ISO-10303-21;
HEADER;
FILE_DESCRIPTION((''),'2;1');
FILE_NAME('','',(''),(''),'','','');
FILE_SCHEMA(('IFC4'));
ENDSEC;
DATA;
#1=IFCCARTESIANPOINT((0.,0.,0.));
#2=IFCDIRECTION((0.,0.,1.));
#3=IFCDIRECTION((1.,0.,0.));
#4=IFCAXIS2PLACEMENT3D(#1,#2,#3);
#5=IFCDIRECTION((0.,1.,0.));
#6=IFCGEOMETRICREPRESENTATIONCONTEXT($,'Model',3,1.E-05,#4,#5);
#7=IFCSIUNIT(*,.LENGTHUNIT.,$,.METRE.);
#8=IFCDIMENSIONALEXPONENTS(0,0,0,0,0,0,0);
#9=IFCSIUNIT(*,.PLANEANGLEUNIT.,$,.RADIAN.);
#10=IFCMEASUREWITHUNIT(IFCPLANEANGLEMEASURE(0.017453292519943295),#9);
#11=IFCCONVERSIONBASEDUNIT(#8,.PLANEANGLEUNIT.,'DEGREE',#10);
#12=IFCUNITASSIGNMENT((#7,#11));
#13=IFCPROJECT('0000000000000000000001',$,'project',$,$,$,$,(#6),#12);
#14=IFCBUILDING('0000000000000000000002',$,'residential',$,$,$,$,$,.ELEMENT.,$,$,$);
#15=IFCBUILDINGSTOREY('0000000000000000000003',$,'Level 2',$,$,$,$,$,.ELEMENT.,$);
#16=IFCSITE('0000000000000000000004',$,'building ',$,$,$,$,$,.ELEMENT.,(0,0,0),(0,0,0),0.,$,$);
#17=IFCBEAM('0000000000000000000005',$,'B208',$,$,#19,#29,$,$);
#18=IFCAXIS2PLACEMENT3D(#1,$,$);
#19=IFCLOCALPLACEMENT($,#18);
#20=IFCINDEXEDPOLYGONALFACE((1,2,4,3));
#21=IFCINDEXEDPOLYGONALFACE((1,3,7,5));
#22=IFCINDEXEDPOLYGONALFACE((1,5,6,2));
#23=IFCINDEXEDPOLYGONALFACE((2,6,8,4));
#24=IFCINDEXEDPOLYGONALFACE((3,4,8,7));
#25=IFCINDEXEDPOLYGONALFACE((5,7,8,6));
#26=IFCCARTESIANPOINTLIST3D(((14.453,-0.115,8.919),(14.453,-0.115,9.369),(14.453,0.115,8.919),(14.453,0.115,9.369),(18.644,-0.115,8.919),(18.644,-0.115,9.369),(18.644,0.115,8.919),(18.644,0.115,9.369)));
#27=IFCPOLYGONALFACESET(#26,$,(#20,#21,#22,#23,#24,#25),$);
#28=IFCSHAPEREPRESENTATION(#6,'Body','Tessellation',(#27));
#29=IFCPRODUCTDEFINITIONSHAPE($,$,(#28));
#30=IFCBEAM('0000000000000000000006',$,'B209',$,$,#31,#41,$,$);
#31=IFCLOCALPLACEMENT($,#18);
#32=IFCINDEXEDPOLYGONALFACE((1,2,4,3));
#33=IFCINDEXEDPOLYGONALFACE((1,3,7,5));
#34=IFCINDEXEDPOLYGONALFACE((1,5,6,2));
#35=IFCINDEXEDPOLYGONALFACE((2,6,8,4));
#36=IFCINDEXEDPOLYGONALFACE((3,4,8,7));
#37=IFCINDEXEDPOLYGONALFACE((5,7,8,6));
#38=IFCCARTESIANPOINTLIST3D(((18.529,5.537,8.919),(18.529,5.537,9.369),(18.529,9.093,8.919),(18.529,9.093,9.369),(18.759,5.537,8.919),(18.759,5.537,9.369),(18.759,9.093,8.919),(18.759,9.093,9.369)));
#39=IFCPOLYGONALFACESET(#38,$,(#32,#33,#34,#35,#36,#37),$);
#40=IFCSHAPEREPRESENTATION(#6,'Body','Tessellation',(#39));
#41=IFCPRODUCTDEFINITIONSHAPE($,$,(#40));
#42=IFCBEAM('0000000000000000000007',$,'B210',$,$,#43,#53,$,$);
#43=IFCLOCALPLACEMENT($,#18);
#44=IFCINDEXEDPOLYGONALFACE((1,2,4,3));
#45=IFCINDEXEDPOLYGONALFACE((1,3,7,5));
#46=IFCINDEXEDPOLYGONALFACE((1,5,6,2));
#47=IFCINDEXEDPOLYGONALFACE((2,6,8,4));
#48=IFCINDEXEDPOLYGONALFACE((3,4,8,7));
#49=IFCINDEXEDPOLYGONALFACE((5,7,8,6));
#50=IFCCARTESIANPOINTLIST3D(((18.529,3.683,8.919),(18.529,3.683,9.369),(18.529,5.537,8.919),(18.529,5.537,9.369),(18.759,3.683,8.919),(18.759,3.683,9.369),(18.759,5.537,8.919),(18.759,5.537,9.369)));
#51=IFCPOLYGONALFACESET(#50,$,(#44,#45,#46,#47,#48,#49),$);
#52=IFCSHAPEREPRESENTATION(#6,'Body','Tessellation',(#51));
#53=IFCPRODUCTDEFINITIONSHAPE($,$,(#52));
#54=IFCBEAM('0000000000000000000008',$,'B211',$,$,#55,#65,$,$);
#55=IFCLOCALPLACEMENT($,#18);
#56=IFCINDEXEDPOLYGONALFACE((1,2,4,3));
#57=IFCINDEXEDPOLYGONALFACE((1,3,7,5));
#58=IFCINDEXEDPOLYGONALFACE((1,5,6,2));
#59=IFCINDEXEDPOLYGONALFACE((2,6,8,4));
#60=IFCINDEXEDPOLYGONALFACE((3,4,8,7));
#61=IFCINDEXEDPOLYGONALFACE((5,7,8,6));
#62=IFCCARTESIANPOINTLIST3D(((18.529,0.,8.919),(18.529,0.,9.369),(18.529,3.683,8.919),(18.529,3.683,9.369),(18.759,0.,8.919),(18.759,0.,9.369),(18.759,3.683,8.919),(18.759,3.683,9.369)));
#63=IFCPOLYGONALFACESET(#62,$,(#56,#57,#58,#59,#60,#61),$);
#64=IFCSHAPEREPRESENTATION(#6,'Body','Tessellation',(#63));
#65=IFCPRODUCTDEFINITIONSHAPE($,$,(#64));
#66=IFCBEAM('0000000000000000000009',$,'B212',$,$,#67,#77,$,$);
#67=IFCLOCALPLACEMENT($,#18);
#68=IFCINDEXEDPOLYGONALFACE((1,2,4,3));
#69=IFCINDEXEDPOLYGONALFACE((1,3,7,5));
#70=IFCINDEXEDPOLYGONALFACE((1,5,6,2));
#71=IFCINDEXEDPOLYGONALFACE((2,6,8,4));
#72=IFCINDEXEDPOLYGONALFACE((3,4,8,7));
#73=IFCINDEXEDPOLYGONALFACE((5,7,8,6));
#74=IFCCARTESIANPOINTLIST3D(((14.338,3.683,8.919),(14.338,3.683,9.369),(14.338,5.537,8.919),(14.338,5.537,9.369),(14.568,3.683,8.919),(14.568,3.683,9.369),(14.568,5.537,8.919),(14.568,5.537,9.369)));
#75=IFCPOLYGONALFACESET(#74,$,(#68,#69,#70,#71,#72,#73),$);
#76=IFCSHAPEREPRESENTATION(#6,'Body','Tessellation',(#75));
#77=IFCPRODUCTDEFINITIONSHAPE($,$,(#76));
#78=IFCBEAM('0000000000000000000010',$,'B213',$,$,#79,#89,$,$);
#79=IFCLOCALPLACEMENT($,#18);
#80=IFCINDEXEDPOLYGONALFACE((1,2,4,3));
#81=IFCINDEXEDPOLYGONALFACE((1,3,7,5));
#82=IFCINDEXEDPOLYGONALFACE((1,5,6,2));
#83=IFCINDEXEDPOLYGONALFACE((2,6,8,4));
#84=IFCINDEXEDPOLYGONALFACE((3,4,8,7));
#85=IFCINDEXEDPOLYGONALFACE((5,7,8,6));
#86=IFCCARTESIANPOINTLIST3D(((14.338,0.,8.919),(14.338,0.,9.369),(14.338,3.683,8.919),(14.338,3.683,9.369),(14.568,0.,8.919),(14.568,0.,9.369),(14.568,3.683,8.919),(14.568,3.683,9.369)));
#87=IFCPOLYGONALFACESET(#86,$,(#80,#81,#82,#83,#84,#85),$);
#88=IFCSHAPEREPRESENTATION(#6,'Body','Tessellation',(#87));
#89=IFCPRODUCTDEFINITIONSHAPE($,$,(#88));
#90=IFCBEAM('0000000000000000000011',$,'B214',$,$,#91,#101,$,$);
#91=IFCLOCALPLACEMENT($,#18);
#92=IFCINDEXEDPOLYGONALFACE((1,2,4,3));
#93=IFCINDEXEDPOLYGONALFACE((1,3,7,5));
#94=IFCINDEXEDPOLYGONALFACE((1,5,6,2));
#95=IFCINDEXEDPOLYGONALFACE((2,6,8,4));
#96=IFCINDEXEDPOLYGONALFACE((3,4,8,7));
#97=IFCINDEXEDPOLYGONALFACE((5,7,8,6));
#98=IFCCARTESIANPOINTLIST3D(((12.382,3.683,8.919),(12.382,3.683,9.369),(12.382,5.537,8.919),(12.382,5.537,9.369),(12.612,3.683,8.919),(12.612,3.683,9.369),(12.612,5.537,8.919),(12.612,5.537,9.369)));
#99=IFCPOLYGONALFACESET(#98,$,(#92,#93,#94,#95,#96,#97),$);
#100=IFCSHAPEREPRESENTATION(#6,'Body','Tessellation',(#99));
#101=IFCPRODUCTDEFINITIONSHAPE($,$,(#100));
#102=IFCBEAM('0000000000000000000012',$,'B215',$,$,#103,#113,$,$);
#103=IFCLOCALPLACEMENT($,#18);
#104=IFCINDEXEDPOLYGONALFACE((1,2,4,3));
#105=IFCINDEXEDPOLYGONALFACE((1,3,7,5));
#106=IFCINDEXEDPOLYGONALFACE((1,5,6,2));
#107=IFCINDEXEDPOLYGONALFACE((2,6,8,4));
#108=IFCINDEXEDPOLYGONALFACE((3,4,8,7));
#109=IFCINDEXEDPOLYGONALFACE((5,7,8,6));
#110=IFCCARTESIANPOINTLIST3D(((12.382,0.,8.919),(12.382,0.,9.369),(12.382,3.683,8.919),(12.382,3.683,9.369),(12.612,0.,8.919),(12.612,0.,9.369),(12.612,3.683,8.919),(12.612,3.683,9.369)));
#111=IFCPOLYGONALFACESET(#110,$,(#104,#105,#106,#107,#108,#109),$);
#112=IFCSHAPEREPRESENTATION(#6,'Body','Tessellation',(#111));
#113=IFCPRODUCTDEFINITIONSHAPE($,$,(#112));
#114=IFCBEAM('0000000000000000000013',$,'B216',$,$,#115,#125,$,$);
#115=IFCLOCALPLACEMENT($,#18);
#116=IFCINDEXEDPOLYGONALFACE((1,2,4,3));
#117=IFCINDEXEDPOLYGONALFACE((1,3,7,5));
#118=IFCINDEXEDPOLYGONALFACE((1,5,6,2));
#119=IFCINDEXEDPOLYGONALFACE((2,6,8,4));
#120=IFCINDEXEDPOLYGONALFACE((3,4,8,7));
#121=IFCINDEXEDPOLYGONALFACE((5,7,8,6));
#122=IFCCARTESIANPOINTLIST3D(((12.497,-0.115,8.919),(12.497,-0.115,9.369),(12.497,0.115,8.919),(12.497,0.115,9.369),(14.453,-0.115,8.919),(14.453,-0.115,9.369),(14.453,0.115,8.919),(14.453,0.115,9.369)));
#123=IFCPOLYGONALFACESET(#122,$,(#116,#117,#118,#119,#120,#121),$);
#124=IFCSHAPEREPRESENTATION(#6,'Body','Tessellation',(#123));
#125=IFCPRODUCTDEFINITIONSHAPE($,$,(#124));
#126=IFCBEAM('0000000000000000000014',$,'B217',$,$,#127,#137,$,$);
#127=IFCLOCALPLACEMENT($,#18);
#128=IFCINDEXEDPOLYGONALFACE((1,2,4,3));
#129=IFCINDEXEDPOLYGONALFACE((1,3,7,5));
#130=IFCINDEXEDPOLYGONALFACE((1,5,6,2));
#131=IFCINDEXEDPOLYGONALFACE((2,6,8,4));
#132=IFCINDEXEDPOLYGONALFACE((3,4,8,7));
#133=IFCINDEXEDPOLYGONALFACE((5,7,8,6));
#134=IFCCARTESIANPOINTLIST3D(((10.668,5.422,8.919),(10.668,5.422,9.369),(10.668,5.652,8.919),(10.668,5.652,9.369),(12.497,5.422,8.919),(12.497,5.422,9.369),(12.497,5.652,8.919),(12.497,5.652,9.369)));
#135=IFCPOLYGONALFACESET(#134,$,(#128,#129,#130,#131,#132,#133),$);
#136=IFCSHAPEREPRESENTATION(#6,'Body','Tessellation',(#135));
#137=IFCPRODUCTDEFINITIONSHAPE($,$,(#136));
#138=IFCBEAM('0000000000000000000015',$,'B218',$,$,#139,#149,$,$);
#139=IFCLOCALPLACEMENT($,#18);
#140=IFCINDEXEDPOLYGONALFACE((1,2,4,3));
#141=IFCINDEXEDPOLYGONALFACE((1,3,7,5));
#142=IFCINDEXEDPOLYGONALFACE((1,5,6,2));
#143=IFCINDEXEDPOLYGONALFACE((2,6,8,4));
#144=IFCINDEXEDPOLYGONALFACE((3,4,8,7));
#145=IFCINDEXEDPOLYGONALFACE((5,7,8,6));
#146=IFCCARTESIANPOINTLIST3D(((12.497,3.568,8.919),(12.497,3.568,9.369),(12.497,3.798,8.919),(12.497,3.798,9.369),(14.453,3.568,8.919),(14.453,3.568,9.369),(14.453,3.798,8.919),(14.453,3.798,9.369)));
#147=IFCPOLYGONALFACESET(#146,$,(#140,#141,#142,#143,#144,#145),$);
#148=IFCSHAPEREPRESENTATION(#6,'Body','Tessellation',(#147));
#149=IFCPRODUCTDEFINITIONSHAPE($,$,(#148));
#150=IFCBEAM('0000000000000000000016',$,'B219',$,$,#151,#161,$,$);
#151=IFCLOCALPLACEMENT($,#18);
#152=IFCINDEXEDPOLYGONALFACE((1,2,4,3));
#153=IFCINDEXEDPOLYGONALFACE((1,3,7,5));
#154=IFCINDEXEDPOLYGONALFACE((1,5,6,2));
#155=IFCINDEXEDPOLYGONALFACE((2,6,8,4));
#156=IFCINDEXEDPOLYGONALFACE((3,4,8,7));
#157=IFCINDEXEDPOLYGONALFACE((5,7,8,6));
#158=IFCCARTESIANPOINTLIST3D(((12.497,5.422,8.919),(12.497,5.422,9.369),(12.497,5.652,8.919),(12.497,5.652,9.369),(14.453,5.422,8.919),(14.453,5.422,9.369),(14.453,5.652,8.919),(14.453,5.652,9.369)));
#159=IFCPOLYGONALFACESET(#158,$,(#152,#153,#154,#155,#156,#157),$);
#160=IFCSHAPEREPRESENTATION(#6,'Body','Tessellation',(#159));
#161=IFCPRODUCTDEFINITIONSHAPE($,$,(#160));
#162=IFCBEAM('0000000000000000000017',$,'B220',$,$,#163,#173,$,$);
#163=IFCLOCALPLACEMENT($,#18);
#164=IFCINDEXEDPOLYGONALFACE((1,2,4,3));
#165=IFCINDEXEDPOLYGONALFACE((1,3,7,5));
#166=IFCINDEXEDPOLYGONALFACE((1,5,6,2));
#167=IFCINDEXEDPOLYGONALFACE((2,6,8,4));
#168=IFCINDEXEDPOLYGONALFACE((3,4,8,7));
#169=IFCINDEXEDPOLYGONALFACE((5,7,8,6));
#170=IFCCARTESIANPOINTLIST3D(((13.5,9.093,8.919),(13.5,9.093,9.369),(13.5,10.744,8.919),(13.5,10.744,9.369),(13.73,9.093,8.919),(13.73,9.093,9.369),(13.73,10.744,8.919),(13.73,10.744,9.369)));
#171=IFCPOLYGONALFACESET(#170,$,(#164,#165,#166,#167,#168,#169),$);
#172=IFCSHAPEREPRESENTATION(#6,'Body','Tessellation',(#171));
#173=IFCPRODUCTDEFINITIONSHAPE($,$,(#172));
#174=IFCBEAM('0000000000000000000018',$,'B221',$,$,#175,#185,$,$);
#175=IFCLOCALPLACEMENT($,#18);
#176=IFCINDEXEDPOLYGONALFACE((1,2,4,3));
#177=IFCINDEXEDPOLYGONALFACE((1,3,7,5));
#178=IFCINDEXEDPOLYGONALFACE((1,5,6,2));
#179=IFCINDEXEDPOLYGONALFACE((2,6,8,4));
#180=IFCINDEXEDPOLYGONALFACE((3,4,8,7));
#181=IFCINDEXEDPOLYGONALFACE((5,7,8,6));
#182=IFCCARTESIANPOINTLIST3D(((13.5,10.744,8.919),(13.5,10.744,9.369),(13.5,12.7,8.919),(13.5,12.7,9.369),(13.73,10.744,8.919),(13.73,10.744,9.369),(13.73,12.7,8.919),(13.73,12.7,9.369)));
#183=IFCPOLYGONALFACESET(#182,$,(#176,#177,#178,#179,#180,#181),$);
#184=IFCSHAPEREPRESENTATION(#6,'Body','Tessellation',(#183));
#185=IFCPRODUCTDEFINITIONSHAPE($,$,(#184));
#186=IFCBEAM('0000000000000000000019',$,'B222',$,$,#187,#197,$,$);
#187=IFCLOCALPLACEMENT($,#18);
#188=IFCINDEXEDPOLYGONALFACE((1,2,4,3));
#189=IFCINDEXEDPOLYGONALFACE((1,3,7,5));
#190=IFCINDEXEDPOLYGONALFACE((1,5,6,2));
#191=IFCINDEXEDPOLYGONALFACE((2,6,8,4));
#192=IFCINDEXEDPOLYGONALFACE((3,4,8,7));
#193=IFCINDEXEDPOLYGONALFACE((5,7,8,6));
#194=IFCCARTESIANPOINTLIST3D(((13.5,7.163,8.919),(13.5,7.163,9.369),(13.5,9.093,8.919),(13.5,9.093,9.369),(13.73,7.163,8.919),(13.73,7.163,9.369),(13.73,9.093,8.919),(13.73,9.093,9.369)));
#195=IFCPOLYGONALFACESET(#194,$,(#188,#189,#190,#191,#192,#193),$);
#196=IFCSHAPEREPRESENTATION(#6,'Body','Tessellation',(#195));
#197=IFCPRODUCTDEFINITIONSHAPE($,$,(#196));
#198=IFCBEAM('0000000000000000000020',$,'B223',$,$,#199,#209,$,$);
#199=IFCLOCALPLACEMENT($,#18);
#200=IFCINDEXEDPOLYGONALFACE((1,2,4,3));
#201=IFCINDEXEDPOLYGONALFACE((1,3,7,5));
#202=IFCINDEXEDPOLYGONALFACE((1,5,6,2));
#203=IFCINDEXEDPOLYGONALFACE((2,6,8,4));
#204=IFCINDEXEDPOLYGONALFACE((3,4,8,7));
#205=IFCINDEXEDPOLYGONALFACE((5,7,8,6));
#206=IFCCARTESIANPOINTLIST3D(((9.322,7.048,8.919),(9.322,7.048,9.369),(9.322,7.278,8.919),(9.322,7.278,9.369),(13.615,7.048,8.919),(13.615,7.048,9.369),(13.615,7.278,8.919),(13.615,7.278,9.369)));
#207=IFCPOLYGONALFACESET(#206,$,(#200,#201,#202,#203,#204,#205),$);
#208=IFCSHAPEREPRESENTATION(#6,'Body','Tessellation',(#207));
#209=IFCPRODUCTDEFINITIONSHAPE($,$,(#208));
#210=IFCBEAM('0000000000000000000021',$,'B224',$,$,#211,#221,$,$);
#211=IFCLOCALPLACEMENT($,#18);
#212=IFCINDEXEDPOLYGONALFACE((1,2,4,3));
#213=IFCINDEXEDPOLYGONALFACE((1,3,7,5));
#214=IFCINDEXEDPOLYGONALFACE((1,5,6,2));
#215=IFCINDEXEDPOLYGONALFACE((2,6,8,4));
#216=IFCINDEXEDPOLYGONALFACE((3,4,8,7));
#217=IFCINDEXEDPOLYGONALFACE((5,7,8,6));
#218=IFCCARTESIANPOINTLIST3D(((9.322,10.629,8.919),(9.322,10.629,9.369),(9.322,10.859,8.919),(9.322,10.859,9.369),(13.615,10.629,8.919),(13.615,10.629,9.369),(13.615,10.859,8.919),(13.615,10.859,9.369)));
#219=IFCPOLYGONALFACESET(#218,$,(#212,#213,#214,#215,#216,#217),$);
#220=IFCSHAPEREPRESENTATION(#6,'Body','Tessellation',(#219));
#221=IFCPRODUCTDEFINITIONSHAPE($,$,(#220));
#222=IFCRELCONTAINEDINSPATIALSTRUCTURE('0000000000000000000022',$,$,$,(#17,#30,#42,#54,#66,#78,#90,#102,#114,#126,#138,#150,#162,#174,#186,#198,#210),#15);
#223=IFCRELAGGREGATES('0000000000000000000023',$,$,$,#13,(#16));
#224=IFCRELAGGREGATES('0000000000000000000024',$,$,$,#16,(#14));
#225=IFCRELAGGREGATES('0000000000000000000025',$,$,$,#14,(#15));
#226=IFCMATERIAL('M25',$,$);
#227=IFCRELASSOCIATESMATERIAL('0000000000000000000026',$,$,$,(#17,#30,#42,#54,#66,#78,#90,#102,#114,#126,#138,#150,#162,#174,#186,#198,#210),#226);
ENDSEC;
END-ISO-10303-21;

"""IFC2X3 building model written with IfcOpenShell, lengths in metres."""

from ifc_helpers import new_model, entity, si_unit, converted_unit, direction, frame, frame_2d, origin_with_axes, place, context, project, spatial, rectangle, extrude, material, element, save


model = new_model("IFC2X3")

# Units and contexts
model_context = context("Model", 3, precision=1e-05, world=origin_with_axes(), true_north=direction((0.0, 1.0, 0.0)))
ifc_project = project(units=[si_unit("LENGTHUNIT", "METRE"), converted_unit("PLANEANGLEUNIT", "DEGREE", entity("IfcPlaneAngleMeasure", 0.017453292519943295), si_unit("PLANEANGLEUNIT", "RADIAN"), dimensions=[0, 0, 0, 0, 0, 0, 0])], contexts=[model_context])

# Site, building, storey
site = spatial("IfcSite", under=ifc_project, Name="building ", CompositionType="ELEMENT", RefLatitude=(0, 0, 0), RefLongitude=(0, 0, 0), RefElevation=0.0)
building = spatial("IfcBuilding", under=site, Name="residential", CompositionType="ELEMENT")
storey = spatial("IfcBuildingStorey", under=building, Name="Level 2", CompositionType="ELEMENT")

# Beams
ifc_material = material(Name="M25")
placement = place(None, origin_with_axes())
element("IfcBeam", 1, at=placement, inside=storey, material=ifc_material, Name="B208", context=model_context, shape_type="SweptSolid", body=[
    extrude(rectangle(XDim=0.23, YDim=0.45, at=frame_2d((0.0, 0.0), x_axis=(0.0, 1.0, 0.0))), frame((18.644, 0.0, 9.144), z_axis=(-1.0, 0.0, 0.0), x_axis=(0.0, 0.0, -1.0)), (0.0, 0.0, 1.0), 4.191),
])
element("IfcBeam", 2, at=placement, inside=storey, material=ifc_material, Name="B209", context=model_context, shape_type="SweptSolid", body=[
    extrude(rectangle(XDim=0.23, YDim=0.45, at=frame_2d((0.0, 0.0), x_axis=(0.0, 1.0, 0.0))), frame((18.644, 9.093, 9.144), z_axis=(0.0, -1.0, 0.0), x_axis=(0.0, 0.0, -1.0)), (0.0, 0.0, 1.0), 3.556),
])
element("IfcBeam", 3, at=placement, inside=storey, material=ifc_material, Name="B210", context=model_context, shape_type="SweptSolid", body=[
    extrude(rectangle(XDim=0.23, YDim=0.45, at=frame_2d((0.0, 0.0), x_axis=(0.0, 1.0, 0.0))), frame((18.644, 3.683, 9.144), z_axis=(0.0, 1.0, 0.0), x_axis=(0.0, 0.0, -1.0)), (0.0, 0.0, 1.0), 1.854),
])
element("IfcBeam", 4, at=placement, inside=storey, material=ifc_material, Name="B211", context=model_context, shape_type="SweptSolid", body=[
    extrude(rectangle(XDim=0.23, YDim=0.45, at=frame_2d((0.0, 0.0), x_axis=(0.0, 1.0, 0.0))), frame((18.644, 0.0, 9.144), z_axis=(0.0, 1.0, 0.0), x_axis=(0.0, 0.0, -1.0)), (0.0, 0.0, 1.0), 3.683),
])
element("IfcBeam", 5, at=placement, inside=storey, material=ifc_material, Name="B212", context=model_context, shape_type="SweptSolid", body=[
    extrude(rectangle(XDim=0.23, YDim=0.45, at=frame_2d((0.0, 0.0), x_axis=(0.0, 1.0, 0.0))), frame((14.453, 3.683, 9.144), z_axis=(0.0, 1.0, 0.0), x_axis=(0.0, 0.0, -1.0)), (0.0, 0.0, 1.0), 1.854),
])
element("IfcBeam", 6, at=placement, inside=storey, material=ifc_material, Name="B213", context=model_context, shape_type="SweptSolid", body=[
    extrude(rectangle(XDim=0.23, YDim=0.45, at=frame_2d((0.0, 0.0), x_axis=(0.0, 1.0, 0.0))), frame((14.453, 0.0, 9.144), z_axis=(0.0, 1.0, 0.0), x_axis=(0.0, 0.0, -1.0)), (0.0, 0.0, 1.0), 3.683),
])
element("IfcBeam", 7, at=placement, inside=storey, material=ifc_material, Name="B214", context=model_context, shape_type="SweptSolid", body=[
    extrude(rectangle(XDim=0.23, YDim=0.45, at=frame_2d((0.0, 0.0), x_axis=(0.0, 1.0, 0.0))), frame((12.497, 3.683, 9.144), z_axis=(0.0, 1.0, 0.0), x_axis=(0.0, 0.0, -1.0)), (0.0, 0.0, 1.0), 1.854),
])
element("IfcBeam", 8, at=placement, inside=storey, material=ifc_material, Name="B215", context=model_context, shape_type="SweptSolid", body=[
    extrude(rectangle(XDim=0.23, YDim=0.45, at=frame_2d((0.0, 0.0), x_axis=(0.0, 1.0, 0.0))), frame((12.497, 0.0, 9.144), z_axis=(0.0, 1.0, 0.0), x_axis=(0.0, 0.0, -1.0)), (0.0, 0.0, 1.0), 3.683),
])
element("IfcBeam", 9, at=placement, inside=storey, material=ifc_material, Name="B216", context=model_context, shape_type="SweptSolid", body=[
    extrude(rectangle(XDim=0.23, YDim=0.45, at=frame_2d((0.0, 0.0), x_axis=(0.0, 1.0, 0.0))), frame((12.497, 0.0, 9.144), z_axis=(1.0, 0.0, 0.0), x_axis=(0.0, 0.0, -1.0)), (0.0, 0.0, 1.0), 1.956),
])
element("IfcBeam", 10, at=placement, inside=storey, material=ifc_material, Name="B217", context=model_context, shape_type="SweptSolid", body=[
    extrude(rectangle(XDim=0.23, YDim=0.45, at=frame_2d((0.0, 0.0), x_axis=(0.0, 1.0, 0.0))), frame((10.668, 5.537, 9.144), z_axis=(1.0, 0.0, 0.0), x_axis=(0.0, 0.0, -1.0)), (0.0, 0.0, 1.0), 1.829),
])
element("IfcBeam", 11, at=placement, inside=storey, material=ifc_material, Name="B218", context=model_context, shape_type="SweptSolid", body=[
    extrude(rectangle(XDim=0.23, YDim=0.45, at=frame_2d((0.0, 0.0), x_axis=(0.0, 1.0, 0.0))), frame((12.497, 3.683, 9.144), z_axis=(1.0, 0.0, 0.0), x_axis=(0.0, 0.0, -1.0)), (0.0, 0.0, 1.0), 1.956),
])
element("IfcBeam", 12, at=placement, inside=storey, material=ifc_material, Name="B219", context=model_context, shape_type="SweptSolid", body=[
    extrude(rectangle(XDim=0.23, YDim=0.45, at=frame_2d((0.0, 0.0), x_axis=(0.0, 1.0, 0.0))), frame((12.497, 5.537, 9.144), z_axis=(1.0, 0.0, 0.0), x_axis=(0.0, 0.0, -1.0)), (0.0, 0.0, 1.0), 1.956),
])
element("IfcBeam", 13, at=placement, inside=storey, material=ifc_material, Name="B220", context=model_context, shape_type="SweptSolid", body=[
    extrude(rectangle(XDim=0.23, YDim=0.45, at=frame_2d((0.0, 0.0), x_axis=(0.0, 1.0, 0.0))), frame((13.615, 9.093, 9.144), z_axis=(0.0, 1.0, 0.0), x_axis=(0.0, 0.0, -1.0)), (0.0, 0.0, 1.0), 1.651),
])
element("IfcBeam", 14, at=placement, inside=storey, material=ifc_material, Name="B221", context=model_context, shape_type="SweptSolid", body=[
    extrude(rectangle(XDim=0.23, YDim=0.45, at=frame_2d((0.0, 0.0), x_axis=(0.0, 1.0, 0.0))), frame((13.615, 10.744, 9.144), z_axis=(0.0, 1.0, 0.0), x_axis=(0.0, 0.0, -1.0)), (0.0, 0.0, 1.0), 1.956),
])
element("IfcBeam", 15, at=placement, inside=storey, material=ifc_material, Name="B222", context=model_context, shape_type="SweptSolid", body=[
    extrude(rectangle(XDim=0.23, YDim=0.45, at=frame_2d((0.0, 0.0), x_axis=(0.0, 1.0, 0.0))), frame((13.615, 7.163, 9.144), z_axis=(0.0, 1.0, 0.0), x_axis=(0.0, 0.0, -1.0)), (0.0, 0.0, 1.0), 1.93),
])
element("IfcBeam", 16, at=placement, inside=storey, material=ifc_material, Name="B223", context=model_context, shape_type="SweptSolid", body=[
    extrude(rectangle(XDim=0.23, YDim=0.45, at=frame_2d((0.0, 0.0), x_axis=(0.0, 1.0, 0.0))), frame((9.322, 7.163, 9.144), z_axis=(1.0, 0.0, 0.0), x_axis=(0.0, 0.0, -1.0)), (0.0, 0.0, 1.0), 4.293),
])
element("IfcBeam", 17, at=placement, inside=storey, material=ifc_material, Name="B224", context=model_context, shape_type="SweptSolid", body=[
    extrude(rectangle(XDim=0.23, YDim=0.45, at=frame_2d((0.0, 0.0), x_axis=(0.0, 1.0, 0.0))), frame((9.322, 10.744, 9.144), z_axis=(1.0, 0.0, 0.0), x_axis=(0.0, 0.0, -1.0)), (0.0, 0.0, 1.0), 4.293),
])

save(model, "model.ifc")
